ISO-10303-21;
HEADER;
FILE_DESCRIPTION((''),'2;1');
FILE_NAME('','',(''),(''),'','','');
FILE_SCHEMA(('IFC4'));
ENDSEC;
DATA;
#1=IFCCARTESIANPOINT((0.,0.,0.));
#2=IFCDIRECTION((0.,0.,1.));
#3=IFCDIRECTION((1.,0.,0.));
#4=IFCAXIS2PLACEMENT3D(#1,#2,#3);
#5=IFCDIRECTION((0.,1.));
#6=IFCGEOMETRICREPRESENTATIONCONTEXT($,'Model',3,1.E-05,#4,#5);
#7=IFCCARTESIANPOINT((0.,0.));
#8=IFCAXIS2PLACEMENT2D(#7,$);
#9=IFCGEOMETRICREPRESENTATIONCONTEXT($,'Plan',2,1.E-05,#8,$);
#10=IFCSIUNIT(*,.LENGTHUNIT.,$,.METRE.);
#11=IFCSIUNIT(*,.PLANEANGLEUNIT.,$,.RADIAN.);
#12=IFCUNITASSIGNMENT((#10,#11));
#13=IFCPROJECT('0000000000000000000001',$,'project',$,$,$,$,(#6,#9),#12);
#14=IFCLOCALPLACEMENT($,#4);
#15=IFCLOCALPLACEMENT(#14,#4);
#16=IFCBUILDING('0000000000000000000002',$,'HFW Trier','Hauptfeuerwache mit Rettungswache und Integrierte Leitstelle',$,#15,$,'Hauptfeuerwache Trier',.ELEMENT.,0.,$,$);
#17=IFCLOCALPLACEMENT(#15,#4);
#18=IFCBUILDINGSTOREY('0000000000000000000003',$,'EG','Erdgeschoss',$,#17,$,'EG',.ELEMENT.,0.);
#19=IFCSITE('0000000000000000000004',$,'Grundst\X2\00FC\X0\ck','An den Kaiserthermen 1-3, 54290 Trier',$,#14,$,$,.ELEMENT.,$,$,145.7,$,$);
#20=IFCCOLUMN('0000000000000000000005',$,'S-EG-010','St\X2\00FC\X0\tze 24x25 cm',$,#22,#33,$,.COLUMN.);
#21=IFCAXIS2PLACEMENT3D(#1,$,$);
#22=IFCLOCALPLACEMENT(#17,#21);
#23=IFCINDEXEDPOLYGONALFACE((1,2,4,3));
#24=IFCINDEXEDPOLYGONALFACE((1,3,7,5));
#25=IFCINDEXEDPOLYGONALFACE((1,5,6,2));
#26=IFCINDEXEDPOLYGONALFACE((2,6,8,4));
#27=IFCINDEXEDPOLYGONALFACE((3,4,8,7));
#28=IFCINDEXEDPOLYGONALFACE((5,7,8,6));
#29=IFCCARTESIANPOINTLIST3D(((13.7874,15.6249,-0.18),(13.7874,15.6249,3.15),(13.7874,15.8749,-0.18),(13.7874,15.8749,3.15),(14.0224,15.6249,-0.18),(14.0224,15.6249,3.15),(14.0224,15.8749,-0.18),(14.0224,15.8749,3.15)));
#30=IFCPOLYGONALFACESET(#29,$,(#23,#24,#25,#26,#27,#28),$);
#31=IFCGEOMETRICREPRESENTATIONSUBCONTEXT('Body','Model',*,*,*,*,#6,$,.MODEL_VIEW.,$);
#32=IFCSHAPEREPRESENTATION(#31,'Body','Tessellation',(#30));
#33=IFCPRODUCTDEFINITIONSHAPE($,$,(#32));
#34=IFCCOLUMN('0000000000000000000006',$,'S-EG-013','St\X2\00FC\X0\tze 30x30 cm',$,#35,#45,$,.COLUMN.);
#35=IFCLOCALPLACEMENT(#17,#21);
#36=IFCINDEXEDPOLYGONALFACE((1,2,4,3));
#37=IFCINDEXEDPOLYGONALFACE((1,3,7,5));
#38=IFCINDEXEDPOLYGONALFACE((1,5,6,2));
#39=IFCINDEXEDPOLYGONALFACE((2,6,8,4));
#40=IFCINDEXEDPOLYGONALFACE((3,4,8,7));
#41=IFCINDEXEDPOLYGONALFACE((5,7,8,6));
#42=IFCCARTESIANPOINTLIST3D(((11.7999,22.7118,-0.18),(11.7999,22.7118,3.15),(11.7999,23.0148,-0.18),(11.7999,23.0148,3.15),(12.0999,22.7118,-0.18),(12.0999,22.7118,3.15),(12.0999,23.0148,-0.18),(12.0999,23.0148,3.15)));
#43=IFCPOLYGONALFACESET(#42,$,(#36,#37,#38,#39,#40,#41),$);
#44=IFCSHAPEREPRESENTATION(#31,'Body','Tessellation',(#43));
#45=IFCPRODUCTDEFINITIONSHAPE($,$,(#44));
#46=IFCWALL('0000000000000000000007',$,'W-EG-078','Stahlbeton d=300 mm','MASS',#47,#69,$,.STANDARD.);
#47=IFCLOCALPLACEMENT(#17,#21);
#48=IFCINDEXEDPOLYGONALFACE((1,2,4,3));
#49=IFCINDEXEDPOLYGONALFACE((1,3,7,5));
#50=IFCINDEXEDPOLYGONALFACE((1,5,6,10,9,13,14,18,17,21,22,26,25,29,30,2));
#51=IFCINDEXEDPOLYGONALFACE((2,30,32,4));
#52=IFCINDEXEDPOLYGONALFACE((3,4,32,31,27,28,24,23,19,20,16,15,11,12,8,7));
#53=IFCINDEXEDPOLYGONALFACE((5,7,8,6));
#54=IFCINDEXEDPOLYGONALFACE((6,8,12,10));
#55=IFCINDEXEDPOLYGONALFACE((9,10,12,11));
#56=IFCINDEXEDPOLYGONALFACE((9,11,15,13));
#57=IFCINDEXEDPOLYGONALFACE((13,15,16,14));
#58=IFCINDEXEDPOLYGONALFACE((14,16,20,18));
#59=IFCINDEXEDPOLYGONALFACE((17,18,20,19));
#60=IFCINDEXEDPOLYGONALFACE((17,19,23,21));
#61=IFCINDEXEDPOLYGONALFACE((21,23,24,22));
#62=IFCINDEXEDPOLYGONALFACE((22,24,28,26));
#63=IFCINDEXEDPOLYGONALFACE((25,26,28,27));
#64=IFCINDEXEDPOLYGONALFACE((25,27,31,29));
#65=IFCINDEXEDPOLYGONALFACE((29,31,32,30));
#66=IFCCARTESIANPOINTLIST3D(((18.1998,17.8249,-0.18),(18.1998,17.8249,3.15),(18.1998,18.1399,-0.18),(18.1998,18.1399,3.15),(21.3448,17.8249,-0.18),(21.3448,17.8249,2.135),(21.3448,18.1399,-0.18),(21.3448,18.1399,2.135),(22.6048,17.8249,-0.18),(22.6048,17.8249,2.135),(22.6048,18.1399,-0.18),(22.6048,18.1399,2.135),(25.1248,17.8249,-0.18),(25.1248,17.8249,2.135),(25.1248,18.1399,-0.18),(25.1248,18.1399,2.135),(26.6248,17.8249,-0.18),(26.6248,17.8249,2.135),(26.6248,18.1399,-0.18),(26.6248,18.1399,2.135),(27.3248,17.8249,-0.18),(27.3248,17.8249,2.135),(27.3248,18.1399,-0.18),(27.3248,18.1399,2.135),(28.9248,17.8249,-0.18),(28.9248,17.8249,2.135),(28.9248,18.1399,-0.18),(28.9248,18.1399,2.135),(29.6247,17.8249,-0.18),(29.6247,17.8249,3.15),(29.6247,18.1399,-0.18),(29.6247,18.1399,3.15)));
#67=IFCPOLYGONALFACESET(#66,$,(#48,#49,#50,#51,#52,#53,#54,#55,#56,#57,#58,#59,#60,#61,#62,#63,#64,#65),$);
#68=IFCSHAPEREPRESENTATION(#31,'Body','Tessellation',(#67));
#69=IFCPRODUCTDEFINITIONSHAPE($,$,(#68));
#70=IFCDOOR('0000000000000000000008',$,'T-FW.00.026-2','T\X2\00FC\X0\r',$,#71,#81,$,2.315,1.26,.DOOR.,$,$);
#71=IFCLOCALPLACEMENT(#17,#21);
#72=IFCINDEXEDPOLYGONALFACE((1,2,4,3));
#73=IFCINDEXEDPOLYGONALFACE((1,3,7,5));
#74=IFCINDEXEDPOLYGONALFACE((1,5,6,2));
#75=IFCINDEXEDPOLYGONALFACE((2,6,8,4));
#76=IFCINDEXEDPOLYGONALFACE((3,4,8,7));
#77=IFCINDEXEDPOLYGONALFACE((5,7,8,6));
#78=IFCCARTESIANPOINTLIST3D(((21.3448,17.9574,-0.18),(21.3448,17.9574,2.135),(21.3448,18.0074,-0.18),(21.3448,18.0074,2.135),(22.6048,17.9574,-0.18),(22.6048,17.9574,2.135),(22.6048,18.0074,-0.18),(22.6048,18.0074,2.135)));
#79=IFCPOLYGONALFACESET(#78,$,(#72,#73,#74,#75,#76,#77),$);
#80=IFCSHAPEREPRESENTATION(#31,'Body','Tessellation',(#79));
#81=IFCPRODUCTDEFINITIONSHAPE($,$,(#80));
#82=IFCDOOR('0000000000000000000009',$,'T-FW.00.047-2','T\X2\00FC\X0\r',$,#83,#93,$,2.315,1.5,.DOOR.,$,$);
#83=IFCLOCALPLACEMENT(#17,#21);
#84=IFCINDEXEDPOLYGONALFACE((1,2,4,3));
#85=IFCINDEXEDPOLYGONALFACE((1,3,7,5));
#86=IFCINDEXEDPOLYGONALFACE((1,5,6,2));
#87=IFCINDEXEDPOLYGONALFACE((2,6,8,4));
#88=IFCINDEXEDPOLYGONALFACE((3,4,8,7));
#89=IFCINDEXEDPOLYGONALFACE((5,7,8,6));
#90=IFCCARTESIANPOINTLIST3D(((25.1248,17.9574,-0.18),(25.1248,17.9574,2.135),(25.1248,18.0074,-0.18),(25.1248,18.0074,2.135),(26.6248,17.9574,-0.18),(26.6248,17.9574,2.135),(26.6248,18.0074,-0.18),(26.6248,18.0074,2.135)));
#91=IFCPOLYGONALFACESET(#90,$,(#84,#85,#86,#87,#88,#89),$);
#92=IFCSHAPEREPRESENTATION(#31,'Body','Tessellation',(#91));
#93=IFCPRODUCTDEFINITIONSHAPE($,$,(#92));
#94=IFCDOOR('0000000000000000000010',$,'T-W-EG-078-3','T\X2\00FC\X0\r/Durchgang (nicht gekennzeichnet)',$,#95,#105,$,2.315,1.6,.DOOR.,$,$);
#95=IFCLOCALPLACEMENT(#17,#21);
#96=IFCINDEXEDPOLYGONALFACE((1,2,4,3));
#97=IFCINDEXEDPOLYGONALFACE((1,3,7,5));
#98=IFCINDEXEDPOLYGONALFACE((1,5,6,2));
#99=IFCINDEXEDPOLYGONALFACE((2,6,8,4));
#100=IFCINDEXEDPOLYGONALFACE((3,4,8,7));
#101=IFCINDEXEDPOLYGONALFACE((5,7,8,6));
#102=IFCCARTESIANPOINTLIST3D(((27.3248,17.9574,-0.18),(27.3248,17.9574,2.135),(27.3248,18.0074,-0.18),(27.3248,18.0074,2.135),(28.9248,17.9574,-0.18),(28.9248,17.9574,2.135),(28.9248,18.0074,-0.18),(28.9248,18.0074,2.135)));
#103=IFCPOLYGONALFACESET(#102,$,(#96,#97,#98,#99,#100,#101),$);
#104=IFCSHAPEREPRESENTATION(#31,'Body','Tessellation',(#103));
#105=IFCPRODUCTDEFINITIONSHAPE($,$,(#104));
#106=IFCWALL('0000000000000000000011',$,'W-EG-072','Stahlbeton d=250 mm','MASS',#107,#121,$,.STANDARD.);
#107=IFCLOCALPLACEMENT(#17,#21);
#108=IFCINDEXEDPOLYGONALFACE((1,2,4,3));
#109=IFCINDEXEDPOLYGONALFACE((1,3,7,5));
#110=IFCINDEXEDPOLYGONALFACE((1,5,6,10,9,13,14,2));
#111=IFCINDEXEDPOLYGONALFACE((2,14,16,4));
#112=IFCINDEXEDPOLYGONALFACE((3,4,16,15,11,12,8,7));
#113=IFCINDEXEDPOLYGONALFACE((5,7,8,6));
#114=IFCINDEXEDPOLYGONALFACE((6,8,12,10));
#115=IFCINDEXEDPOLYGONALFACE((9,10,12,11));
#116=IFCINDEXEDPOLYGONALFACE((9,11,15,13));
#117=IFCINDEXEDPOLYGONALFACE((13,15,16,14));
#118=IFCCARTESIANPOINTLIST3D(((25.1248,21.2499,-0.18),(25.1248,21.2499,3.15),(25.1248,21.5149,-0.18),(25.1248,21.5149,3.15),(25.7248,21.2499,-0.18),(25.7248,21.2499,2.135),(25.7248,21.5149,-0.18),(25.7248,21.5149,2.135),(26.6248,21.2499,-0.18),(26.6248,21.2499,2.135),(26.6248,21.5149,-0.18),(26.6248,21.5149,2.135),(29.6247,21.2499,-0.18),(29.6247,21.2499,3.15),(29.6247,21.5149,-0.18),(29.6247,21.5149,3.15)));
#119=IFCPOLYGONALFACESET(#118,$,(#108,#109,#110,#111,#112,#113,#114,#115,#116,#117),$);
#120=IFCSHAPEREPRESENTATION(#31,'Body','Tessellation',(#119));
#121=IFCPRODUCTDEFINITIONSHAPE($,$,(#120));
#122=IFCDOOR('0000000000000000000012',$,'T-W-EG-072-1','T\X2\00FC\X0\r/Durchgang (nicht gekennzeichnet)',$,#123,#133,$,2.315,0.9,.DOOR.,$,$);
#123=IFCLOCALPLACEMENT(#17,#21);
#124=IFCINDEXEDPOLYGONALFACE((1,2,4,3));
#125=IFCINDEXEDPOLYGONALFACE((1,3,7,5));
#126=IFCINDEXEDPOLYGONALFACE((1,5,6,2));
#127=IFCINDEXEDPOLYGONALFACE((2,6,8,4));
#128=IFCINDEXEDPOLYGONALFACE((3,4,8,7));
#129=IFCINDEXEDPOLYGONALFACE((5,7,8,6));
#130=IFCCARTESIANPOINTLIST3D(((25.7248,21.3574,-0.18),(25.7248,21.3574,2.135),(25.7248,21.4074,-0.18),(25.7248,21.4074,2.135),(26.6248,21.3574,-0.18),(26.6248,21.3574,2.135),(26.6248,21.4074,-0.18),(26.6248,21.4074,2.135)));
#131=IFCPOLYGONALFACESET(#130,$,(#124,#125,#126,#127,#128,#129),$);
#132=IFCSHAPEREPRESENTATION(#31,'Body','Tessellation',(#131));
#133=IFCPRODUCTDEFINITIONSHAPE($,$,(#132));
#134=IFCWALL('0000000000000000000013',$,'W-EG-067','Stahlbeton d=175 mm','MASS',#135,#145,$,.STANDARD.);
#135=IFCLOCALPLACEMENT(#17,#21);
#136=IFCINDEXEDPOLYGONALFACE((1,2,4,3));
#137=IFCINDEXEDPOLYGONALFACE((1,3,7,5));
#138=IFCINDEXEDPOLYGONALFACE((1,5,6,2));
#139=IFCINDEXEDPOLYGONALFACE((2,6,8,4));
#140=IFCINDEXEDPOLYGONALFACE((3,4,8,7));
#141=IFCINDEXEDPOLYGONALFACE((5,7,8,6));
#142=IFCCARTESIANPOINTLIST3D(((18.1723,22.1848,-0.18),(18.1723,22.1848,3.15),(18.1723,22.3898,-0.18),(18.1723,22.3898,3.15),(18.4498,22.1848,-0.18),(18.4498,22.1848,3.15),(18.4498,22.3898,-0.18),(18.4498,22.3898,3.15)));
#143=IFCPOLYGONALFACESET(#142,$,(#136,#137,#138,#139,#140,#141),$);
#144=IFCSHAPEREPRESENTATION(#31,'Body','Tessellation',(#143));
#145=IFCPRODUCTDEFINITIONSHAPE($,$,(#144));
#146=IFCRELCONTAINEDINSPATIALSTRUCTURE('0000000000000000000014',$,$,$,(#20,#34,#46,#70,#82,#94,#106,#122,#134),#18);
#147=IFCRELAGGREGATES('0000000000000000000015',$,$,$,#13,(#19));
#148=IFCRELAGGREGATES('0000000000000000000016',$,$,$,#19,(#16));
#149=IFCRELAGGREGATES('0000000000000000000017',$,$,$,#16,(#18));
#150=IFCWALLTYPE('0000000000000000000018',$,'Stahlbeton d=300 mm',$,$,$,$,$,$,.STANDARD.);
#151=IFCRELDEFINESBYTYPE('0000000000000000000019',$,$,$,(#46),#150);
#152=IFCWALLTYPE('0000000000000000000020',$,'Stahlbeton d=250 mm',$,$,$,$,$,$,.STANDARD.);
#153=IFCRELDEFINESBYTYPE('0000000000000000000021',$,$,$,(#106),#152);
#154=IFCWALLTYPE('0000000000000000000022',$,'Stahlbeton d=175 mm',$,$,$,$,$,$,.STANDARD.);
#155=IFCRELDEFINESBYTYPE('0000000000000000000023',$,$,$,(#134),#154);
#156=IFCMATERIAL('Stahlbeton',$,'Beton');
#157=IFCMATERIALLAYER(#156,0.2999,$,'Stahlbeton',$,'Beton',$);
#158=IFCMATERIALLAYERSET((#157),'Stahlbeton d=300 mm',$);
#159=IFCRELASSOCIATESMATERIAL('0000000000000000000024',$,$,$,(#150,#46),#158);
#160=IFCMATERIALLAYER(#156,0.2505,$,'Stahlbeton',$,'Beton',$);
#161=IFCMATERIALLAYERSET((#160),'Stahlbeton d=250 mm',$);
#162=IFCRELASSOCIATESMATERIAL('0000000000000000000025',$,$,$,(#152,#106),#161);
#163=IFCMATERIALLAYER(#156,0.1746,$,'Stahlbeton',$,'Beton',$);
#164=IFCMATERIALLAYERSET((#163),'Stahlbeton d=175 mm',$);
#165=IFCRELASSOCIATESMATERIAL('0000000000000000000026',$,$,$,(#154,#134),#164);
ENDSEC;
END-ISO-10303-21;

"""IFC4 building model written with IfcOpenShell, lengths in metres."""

from ifc_helpers import new_model, si_unit, direction, frame, frame_2d, origin_with_axes, origin_2d, place, context, subcontext, project, spatial, rectangle, extrude, material, layer, layer_set, layer_usage, type_object, element, fill, save


model = new_model("IFC4")

# Units and contexts
model_context = context("Model", 3, precision=1e-05, world=origin_with_axes(), true_north=direction((0.0, 1.0)))
plan_context = context("Plan", 2, precision=1e-05, world=origin_2d())
body_context = subcontext(model_context, "Body", "Model", "MODEL_VIEW")
ifc_project = project(units=[si_unit("LENGTHUNIT", "METRE"), si_unit("PLANEANGLEUNIT", "RADIAN")], contexts=[model_context, plan_context])

# Site, building, storey
site_placement = place(None, origin_with_axes())
site = spatial("IfcSite", under=ifc_project, at=site_placement, Name="Grundstück", Description="An den Kaiserthermen 1-3, 54290 Trier", CompositionType="ELEMENT", RefElevation=145.7)
building_placement = place(site_placement, origin_with_axes())
building = spatial("IfcBuilding", under=site, at=building_placement, Name="HFW Trier", Description="Hauptfeuerwache mit Rettungswache und Integrierte Leitstelle", LongName="Hauptfeuerwache Trier", CompositionType="ELEMENT", ElevationOfRefHeight=0.0)
storey_placement = place(building_placement, origin_with_axes())
storey = spatial("IfcBuildingStorey", under=building, at=storey_placement, Name="EG", Description="Erdgeschoss", LongName="EG", CompositionType="ELEMENT", Elevation=0.0)

# Columns
column_1_placement = place(storey_placement, frame((13.7874, 15.7499, -0.18), z_axis=(0.0, 0.0, 1.0), x_axis=(1.0, 0.0, 0.0)))
element("IfcColumn", 1, at=column_1_placement, inside=storey, Name="S-EG-010", Description="Stütze 24x25 cm", PredefinedType="COLUMN", context=body_context, shape_type="SweptSolid", body=[
    extrude(rectangle(XDim=0.235, YDim=0.25, at=frame_2d((0.1175, 0.0))), origin_with_axes(), (0.0, 0.0, 1.0), 3.33),
])
column_2_placement = place(storey_placement, frame((11.7999, 22.8633, -0.18), z_axis=(0.0, 0.0, 1.0), x_axis=(1.0, 0.0, 0.0)))
element("IfcColumn", 2, at=column_2_placement, inside=storey, Name="S-EG-013", Description="Stütze 30x30 cm", PredefinedType="COLUMN", context=body_context, shape_type="SweptSolid", body=[
    extrude(rectangle(XDim=0.3, YDim=0.303, at=frame_2d((0.15, 0.0))), origin_with_axes(), (0.0, 0.0, 1.0), 3.33),
])

# Wall, openings, doors
ifc_material_1 = material(Name="Stahlbeton", Category="Beton")
ifc_layer_1 = layer(ifc_material_1, 0.2999, Name="Stahlbeton", Category="Beton")
ifc_layer_set_1 = layer_set([ifc_layer_1], Name="Stahlbeton d=300 mm")
ifc_layer_usage_1 = layer_usage(ifc_layer_set_1, "AXIS2", "POSITIVE", -0.1575)
wall_type_1 = type_object("IfcWallType", Name="Stahlbeton d=300 mm", PredefinedType="STANDARD", material=ifc_layer_set_1)
wall_1_placement = place(storey_placement, frame((18.1998, 17.9824, -0.18), z_axis=(0.0, 0.0, 1.0), x_axis=(1.0, 0.0, 0.0)))
wall_1 = element("IfcWall", 3, at=wall_1_placement, inside=storey, type_object=wall_type_1, material=ifc_layer_usage_1, Name="W-EG-078", Description="Stahlbeton d=300 mm", ObjectType="MASS", PredefinedType="STANDARD", context=body_context, shape_type="SweptSolid", body=[
    extrude(rectangle(XDim=11.4249, YDim=0.315, at=frame_2d((5.7125, 0.0))), origin_with_axes(), (0.0, 0.0, 1.0), 3.33),
])
opening_1_placement = place(wall_1_placement, frame((3.145, 0.0, 0.0), z_axis=(0.0, 0.0, 1.0), x_axis=(1.0, 0.0, 0.0)))
opening_1 = element("IfcOpeningElement", 4, at=opening_1_placement, cuts=wall_1, PredefinedType="OPENING", context=body_context, shape_type="SweptSolid", body=[
    extrude(rectangle(XDim=1.26, YDim=0.415, at=frame_2d((0.63, 0.0))), origin_with_axes(), (0.0, 0.0, 1.0), 2.315),
])
opening_2_placement = place(wall_1_placement, frame((6.925, 0.0, 0.0), z_axis=(0.0, 0.0, 1.0), x_axis=(1.0, 0.0, 0.0)))
opening_2 = element("IfcOpeningElement", 5, at=opening_2_placement, cuts=wall_1, PredefinedType="OPENING", context=body_context, shape_type="SweptSolid", body=[
    extrude(rectangle(XDim=1.5, YDim=0.415, at=frame_2d((0.75, 0.0))), origin_with_axes(), (0.0, 0.0, 1.0), 2.315),
])
opening_3_placement = place(wall_1_placement, frame((9.125, 0.0, 0.0), z_axis=(0.0, 0.0, 1.0), x_axis=(1.0, 0.0, 0.0)))
opening_3 = element("IfcOpeningElement", 6, at=opening_3_placement, cuts=wall_1, PredefinedType="OPENING", context=body_context, shape_type="SweptSolid", body=[
    extrude(rectangle(XDim=1.6, YDim=0.415, at=frame_2d((0.8, 0.0))), origin_with_axes(), (0.0, 0.0, 1.0), 2.315),
])
door_1_placement = place(wall_1_placement, frame((3.145, 0.0, 0.0), z_axis=(0.0, 0.0, 1.0), x_axis=(1.0, 0.0, 0.0)))
door_1 = element("IfcDoor", 7, at=door_1_placement, inside=storey, Name="T-FW.00.026-2", Description="Tür", OverallHeight=2.315, OverallWidth=1.26, PredefinedType="DOOR", context=body_context, shape_type="SweptSolid", body=[
    extrude(rectangle(XDim=1.26, YDim=0.05, at=frame_2d((0.63, 0.0))), origin_with_axes(), (0.0, 0.0, 1.0), 2.315),
])
fill(opening_1, door_1)
door_2_placement = place(wall_1_placement, frame((6.925, 0.0, 0.0), z_axis=(0.0, 0.0, 1.0), x_axis=(1.0, 0.0, 0.0)))
door_2 = element("IfcDoor", 8, at=door_2_placement, inside=storey, Name="T-FW.00.047-2", Description="Tür", OverallHeight=2.315, OverallWidth=1.5, PredefinedType="DOOR", context=body_context, shape_type="SweptSolid", body=[
    extrude(rectangle(XDim=1.5, YDim=0.05, at=frame_2d((0.75, 0.0))), origin_with_axes(), (0.0, 0.0, 1.0), 2.315),
])
fill(opening_2, door_2)
door_3_placement = place(wall_1_placement, frame((9.125, 0.0, 0.0), z_axis=(0.0, 0.0, 1.0), x_axis=(1.0, 0.0, 0.0)))
door_3 = element("IfcDoor", 9, at=door_3_placement, inside=storey, Name="T-W-EG-078-3", Description="Tür/Durchgang (nicht gekennzeichnet)", OverallHeight=2.315, OverallWidth=1.6, PredefinedType="DOOR", context=body_context, shape_type="SweptSolid", body=[
    extrude(rectangle(XDim=1.6, YDim=0.05, at=frame_2d((0.8, 0.0))), origin_with_axes(), (0.0, 0.0, 1.0), 2.315),
])
fill(opening_3, door_3)

# Wall, opening, door
ifc_layer_2 = layer(ifc_material_1, 0.2505, Name="Stahlbeton", Category="Beton")
ifc_layer_set_2 = layer_set([ifc_layer_2], Name="Stahlbeton d=250 mm")
ifc_layer_usage_2 = layer_usage(ifc_layer_set_2, "AXIS2", "POSITIVE", -0.1325)
wall_type_2 = type_object("IfcWallType", Name="Stahlbeton d=250 mm", PredefinedType="STANDARD", material=ifc_layer_set_2)
wall_2_placement = place(storey_placement, frame((25.1248, 21.3824, -0.18), z_axis=(0.0, 0.0, 1.0), x_axis=(1.0, 0.0, 0.0)))
wall_2 = element("IfcWall", 10, at=wall_2_placement, inside=storey, type_object=wall_type_2, material=ifc_layer_usage_2, Name="W-EG-072", Description="Stahlbeton d=250 mm", ObjectType="MASS", PredefinedType="STANDARD", context=body_context, shape_type="SweptSolid", body=[
    extrude(rectangle(XDim=4.4999, YDim=0.265, at=frame_2d((2.25, 0.0))), origin_with_axes(), (0.0, 0.0, 1.0), 3.33),
])
opening_4_placement = place(wall_2_placement, frame((0.6, 0.0, 0.0), z_axis=(0.0, 0.0, 1.0), x_axis=(1.0, 0.0, 0.0)))
opening_4 = element("IfcOpeningElement", 11, at=opening_4_placement, cuts=wall_2, PredefinedType="OPENING", context=body_context, shape_type="SweptSolid", body=[
    extrude(rectangle(XDim=0.9, YDim=0.365, at=frame_2d((0.45, 0.0))), origin_with_axes(), (0.0, 0.0, 1.0), 2.315),
])
door_4_placement = place(wall_2_placement, frame((0.6, 0.0, 0.0), z_axis=(0.0, 0.0, 1.0), x_axis=(1.0, 0.0, 0.0)))
door_4 = element("IfcDoor", 12, at=door_4_placement, inside=storey, Name="T-W-EG-072-1", Description="Tür/Durchgang (nicht gekennzeichnet)", OverallHeight=2.315, OverallWidth=0.9, PredefinedType="DOOR", context=body_context, shape_type="SweptSolid", body=[
    extrude(rectangle(XDim=0.9, YDim=0.05, at=frame_2d((0.45, 0.0))), origin_with_axes(), (0.0, 0.0, 1.0), 2.315),
])
fill(opening_4, door_4)

# Wall
ifc_layer_3 = layer(ifc_material_1, 0.1746, Name="Stahlbeton", Category="Beton")
ifc_layer_set_3 = layer_set([ifc_layer_3], Name="Stahlbeton d=175 mm")
ifc_layer_usage_3 = layer_usage(ifc_layer_set_3, "AXIS2", "POSITIVE", -0.1025)
wall_type_3 = type_object("IfcWallType", Name="Stahlbeton d=175 mm", PredefinedType="STANDARD", material=ifc_layer_set_3)
wall_3_placement = place(storey_placement, frame((18.1723, 22.2873, -0.18), z_axis=(0.0, 0.0, 1.0), x_axis=(1.0, 0.0, 0.0)))
element("IfcWall", 13, at=wall_3_placement, inside=storey, type_object=wall_type_3, material=ifc_layer_usage_3, Name="W-EG-067", Description="Stahlbeton d=175 mm", ObjectType="MASS", PredefinedType="STANDARD", context=body_context, shape_type="SweptSolid", body=[
    extrude(rectangle(XDim=0.2775, YDim=0.205, at=frame_2d((0.1387, 0.0))), origin_with_axes(), (0.0, 0.0, 1.0), 3.33),
])

save(model, "model.ifc")
